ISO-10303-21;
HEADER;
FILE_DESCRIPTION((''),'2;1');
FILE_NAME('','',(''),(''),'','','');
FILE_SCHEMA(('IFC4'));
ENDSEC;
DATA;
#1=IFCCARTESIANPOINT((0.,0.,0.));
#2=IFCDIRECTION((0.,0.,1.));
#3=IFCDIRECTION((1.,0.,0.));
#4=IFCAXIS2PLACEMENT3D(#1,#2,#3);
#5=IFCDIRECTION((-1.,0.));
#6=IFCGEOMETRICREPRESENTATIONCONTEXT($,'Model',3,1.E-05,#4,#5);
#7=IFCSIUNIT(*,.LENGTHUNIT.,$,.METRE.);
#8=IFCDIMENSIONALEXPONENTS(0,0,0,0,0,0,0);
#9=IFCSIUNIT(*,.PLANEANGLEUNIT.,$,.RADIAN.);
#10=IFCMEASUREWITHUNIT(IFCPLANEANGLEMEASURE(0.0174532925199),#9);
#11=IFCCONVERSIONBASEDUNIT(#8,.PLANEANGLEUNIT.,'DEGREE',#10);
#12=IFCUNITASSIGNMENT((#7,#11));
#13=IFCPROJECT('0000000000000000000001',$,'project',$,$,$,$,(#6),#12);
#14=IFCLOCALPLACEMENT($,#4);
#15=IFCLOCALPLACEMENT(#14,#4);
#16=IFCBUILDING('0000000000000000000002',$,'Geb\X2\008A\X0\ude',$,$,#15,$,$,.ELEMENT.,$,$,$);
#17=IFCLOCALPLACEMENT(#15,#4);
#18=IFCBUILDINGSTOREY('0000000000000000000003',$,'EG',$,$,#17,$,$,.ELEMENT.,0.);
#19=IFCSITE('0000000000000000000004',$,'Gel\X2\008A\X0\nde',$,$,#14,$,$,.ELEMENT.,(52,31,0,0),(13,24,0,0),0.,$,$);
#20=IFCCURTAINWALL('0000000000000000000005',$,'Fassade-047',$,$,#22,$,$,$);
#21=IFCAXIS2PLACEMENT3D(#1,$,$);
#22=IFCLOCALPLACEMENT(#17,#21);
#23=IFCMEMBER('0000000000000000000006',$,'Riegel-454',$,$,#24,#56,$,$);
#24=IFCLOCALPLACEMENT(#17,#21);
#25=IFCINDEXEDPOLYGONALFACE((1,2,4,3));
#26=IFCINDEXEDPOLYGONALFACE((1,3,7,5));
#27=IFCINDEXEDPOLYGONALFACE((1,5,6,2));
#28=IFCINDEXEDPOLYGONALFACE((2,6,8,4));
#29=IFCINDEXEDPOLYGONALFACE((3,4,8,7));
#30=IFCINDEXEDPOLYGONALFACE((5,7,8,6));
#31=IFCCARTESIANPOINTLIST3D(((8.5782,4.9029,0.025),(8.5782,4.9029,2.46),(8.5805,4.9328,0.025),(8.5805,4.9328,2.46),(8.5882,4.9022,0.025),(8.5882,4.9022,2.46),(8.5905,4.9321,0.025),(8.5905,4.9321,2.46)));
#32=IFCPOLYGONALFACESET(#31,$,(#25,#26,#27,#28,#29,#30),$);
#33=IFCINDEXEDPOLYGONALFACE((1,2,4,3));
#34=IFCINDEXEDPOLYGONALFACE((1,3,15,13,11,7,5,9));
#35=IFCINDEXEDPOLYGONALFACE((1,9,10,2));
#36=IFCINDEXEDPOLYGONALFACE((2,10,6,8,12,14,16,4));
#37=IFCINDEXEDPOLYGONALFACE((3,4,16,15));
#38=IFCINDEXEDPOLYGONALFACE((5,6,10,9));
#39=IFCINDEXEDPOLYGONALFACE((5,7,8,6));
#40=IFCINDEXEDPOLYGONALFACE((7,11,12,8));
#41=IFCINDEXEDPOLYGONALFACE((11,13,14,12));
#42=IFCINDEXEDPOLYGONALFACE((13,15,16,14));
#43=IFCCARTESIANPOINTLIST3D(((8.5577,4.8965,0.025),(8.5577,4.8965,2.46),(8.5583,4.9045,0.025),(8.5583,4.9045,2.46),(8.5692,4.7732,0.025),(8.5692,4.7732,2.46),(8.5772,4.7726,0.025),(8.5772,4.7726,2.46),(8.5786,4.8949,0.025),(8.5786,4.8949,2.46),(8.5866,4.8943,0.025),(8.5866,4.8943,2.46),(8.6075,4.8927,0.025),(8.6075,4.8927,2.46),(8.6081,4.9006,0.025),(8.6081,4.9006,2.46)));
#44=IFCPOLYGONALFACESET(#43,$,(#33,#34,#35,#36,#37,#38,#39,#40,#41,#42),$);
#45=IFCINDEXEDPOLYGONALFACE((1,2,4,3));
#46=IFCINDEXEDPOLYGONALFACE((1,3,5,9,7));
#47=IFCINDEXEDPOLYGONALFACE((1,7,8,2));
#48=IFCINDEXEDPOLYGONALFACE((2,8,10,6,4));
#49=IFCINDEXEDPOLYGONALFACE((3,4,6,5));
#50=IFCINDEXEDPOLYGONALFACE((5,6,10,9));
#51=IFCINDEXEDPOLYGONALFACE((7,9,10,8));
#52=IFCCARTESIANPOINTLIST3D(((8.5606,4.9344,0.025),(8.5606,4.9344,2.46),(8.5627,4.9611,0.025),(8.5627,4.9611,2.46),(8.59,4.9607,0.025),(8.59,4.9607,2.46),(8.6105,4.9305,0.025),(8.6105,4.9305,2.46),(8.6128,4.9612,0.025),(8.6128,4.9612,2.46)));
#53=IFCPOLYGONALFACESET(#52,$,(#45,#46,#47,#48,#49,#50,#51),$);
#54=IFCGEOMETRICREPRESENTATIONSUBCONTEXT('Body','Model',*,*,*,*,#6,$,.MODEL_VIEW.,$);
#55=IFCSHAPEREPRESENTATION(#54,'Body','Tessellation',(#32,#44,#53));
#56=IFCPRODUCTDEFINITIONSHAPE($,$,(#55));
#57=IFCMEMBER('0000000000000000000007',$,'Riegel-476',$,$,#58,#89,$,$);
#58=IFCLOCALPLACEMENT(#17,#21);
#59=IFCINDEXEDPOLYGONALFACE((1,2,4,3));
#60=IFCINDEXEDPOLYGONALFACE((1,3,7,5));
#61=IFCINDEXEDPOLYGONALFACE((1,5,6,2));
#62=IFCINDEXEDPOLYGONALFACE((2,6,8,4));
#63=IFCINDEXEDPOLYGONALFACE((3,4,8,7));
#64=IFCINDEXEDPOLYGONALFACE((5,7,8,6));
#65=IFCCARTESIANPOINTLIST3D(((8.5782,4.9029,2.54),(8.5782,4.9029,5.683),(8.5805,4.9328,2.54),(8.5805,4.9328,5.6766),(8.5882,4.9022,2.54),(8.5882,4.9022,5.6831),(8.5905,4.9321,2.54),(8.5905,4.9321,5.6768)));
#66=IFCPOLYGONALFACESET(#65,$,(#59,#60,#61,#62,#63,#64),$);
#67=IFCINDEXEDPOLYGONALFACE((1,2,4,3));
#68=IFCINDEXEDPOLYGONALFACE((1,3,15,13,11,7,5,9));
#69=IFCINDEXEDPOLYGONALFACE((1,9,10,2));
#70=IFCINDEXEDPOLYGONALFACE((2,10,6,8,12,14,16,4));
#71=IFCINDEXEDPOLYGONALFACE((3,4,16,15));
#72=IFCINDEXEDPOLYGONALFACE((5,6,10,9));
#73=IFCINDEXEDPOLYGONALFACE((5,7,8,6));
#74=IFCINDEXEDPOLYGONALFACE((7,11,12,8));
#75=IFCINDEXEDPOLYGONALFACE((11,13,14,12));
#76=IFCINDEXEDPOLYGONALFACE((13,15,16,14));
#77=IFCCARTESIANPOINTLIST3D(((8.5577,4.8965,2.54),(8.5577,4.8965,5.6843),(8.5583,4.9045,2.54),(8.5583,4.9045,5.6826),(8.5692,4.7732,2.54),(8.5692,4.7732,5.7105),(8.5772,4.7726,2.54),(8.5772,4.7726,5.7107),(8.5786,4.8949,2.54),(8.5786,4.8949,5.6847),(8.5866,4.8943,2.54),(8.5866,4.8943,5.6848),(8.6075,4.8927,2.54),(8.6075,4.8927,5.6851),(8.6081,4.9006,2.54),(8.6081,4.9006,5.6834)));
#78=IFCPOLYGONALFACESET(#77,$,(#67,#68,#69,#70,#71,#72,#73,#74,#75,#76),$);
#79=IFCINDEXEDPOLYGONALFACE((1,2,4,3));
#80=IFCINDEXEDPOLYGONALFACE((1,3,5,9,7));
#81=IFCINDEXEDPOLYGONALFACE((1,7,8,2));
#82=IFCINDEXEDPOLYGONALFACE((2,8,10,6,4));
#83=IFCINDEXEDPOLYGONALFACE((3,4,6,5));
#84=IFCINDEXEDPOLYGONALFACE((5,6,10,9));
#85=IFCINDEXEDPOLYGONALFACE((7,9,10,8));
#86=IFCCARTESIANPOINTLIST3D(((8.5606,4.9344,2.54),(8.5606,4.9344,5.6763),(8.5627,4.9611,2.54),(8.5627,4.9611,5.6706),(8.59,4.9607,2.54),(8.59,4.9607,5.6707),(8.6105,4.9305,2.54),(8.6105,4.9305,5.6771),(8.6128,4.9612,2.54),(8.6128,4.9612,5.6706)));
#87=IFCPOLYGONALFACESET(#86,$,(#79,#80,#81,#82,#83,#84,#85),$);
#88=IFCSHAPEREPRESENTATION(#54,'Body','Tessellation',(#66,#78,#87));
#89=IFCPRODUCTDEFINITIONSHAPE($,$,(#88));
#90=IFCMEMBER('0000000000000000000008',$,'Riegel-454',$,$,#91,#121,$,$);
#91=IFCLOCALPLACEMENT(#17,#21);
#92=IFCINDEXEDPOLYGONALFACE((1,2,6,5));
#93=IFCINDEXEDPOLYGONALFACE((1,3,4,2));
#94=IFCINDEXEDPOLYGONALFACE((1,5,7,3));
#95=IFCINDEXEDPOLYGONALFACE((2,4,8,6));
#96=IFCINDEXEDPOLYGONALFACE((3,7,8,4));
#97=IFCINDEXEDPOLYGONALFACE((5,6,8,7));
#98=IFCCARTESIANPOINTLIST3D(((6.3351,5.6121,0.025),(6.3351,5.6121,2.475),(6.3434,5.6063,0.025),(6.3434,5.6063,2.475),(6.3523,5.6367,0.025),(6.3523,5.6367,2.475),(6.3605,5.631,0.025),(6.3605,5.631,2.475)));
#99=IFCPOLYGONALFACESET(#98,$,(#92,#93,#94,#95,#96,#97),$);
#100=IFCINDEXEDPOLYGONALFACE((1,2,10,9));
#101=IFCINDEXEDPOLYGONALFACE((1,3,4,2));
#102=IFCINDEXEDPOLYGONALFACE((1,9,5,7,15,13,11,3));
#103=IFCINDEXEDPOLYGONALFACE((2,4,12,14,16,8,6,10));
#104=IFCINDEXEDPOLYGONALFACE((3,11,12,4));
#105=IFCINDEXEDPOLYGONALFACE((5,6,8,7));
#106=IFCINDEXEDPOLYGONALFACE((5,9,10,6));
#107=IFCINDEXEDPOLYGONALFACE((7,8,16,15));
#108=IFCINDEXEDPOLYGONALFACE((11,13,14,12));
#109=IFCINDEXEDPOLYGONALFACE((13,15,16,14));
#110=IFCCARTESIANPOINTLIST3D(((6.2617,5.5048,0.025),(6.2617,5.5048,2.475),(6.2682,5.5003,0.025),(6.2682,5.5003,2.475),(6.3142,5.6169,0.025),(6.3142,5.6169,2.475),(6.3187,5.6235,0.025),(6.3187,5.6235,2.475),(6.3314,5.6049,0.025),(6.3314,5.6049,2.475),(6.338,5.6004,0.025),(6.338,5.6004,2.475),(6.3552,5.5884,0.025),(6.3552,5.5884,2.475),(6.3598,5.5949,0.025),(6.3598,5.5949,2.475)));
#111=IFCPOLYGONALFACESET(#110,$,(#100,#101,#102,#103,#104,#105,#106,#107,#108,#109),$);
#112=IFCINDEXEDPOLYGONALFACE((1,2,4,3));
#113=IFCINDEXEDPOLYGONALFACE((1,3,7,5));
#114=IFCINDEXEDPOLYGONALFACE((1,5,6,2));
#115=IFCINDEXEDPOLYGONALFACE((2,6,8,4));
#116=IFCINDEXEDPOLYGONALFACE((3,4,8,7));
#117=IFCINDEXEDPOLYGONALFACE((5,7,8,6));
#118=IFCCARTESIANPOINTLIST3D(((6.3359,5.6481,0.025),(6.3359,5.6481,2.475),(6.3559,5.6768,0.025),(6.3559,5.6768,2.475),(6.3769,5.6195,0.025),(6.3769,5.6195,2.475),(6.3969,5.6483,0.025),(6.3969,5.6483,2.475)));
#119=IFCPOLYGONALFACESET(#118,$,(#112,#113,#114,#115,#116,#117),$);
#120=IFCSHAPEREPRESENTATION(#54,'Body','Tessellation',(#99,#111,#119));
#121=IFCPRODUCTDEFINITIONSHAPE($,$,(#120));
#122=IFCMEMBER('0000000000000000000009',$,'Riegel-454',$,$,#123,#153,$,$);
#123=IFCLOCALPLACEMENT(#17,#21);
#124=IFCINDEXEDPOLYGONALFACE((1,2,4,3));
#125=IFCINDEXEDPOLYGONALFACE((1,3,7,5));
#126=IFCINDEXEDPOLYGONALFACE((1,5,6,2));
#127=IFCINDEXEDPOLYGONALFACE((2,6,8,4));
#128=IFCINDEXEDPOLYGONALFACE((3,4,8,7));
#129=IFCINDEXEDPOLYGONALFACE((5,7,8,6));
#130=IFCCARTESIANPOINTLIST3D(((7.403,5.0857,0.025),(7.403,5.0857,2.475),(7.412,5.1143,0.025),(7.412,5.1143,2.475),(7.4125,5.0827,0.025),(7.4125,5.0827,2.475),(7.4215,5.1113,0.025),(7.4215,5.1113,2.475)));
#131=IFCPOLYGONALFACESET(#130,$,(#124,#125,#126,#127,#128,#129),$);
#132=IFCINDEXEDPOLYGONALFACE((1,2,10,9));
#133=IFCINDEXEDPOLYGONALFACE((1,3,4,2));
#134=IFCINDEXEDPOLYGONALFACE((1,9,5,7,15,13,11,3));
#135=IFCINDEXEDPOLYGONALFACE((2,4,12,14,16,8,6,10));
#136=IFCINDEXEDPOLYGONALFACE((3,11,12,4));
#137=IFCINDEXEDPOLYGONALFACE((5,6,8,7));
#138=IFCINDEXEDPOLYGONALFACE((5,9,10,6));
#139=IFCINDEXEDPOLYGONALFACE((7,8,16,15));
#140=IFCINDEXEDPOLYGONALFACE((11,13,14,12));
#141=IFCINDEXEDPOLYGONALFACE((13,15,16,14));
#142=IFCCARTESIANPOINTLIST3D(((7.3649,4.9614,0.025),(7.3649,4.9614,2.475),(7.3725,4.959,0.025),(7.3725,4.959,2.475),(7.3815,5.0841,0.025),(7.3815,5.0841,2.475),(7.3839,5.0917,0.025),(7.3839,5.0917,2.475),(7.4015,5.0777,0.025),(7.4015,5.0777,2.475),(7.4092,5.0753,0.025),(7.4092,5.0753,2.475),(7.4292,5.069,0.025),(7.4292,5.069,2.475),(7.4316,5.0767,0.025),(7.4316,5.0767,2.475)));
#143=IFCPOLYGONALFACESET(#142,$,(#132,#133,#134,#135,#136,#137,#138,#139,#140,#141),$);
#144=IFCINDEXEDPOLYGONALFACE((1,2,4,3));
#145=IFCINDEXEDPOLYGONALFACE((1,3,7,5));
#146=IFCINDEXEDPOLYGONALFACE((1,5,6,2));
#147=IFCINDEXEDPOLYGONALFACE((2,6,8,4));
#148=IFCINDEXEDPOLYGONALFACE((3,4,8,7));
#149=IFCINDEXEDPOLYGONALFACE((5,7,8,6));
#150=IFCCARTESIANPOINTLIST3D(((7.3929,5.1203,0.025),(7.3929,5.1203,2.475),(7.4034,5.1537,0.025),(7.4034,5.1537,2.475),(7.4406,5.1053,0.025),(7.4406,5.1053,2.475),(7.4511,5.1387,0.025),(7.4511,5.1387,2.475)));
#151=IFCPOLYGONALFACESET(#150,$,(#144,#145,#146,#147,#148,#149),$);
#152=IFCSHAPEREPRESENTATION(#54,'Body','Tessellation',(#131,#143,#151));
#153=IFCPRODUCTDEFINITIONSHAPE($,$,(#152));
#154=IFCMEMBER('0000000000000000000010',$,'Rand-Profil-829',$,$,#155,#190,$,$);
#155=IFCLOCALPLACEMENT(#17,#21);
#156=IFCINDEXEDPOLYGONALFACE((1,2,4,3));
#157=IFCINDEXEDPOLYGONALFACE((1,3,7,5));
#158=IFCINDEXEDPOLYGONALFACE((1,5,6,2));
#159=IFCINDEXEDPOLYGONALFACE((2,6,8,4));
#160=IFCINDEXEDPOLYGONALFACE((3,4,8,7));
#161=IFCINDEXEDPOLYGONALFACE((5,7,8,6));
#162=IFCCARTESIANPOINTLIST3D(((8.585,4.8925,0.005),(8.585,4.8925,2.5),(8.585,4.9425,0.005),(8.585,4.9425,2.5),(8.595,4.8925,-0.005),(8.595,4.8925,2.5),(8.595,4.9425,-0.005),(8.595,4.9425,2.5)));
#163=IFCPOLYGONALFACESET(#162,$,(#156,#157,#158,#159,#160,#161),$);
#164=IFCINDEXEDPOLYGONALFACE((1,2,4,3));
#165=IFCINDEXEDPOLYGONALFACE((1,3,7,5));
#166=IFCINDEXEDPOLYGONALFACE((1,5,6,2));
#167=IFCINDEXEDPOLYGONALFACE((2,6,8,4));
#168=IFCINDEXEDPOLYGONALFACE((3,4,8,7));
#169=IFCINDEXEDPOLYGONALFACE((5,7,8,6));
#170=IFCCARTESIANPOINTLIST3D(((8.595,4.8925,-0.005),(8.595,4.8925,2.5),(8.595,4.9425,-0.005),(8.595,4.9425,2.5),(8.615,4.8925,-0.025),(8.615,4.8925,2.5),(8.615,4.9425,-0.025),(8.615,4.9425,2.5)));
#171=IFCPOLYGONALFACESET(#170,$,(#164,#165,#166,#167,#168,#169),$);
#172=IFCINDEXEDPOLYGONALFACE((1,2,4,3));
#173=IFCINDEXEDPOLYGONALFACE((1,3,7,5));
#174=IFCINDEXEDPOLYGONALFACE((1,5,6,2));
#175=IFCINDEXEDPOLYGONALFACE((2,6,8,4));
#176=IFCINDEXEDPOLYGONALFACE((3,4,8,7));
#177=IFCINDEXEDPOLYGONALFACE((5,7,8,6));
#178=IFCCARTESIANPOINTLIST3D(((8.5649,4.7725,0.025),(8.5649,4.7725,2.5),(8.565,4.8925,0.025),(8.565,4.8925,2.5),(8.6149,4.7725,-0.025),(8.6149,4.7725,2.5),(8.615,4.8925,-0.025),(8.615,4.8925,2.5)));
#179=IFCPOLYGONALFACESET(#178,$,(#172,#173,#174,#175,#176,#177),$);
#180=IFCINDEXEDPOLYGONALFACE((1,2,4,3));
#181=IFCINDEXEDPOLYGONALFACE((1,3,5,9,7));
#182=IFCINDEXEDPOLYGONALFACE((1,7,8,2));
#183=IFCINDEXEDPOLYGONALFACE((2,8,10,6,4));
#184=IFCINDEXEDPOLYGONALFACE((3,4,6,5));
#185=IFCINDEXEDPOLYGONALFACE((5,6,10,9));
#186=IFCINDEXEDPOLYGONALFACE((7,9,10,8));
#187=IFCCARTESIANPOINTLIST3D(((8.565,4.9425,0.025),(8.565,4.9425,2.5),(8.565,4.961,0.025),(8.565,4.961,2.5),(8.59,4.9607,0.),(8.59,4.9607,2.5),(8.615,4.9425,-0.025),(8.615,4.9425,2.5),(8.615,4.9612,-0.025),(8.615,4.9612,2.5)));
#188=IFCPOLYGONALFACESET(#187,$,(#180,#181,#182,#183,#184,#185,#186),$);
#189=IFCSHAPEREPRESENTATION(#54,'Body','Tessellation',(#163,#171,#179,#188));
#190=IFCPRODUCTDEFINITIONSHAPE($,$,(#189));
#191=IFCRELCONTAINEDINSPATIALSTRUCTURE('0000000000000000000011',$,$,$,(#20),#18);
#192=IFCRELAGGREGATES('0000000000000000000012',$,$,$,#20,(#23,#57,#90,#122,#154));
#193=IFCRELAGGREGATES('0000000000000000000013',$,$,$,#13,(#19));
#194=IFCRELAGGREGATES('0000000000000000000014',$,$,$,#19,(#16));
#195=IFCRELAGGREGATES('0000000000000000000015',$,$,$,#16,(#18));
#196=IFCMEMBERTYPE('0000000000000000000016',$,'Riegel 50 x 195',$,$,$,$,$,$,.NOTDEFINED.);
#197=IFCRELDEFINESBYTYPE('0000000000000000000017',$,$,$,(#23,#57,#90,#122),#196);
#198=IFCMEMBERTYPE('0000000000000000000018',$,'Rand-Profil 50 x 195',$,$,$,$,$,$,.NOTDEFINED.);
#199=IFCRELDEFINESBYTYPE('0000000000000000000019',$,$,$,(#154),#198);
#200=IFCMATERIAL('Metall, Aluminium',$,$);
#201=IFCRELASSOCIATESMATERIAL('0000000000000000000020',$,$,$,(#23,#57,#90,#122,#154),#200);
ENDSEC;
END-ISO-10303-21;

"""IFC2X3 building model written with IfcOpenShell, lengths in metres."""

from ifc_helpers import new_model, entity, si_unit, converted_unit, direction, frame, origin_with_axes, place, context, subcontext, project, spatial, polyline, outline, extrude, clip, halfspace, material, type_object, element, aggregate, save


model = new_model("IFC2X3")

# Units and contexts
model_context = context("Model", 3, precision=1e-05, world=origin_with_axes(), true_north=direction((-1.0, 0.0)))
body_context = subcontext(model_context, "Body", "Model", "MODEL_VIEW")
ifc_project = project(units=[si_unit("LENGTHUNIT", "METRE"), converted_unit("PLANEANGLEUNIT", "DEGREE", entity("IfcPlaneAngleMeasure", 0.0174532925199), si_unit("PLANEANGLEUNIT", "RADIAN"), dimensions=[0, 0, 0, 0, 0, 0, 0])], contexts=[model_context])

# Site, building, storey
site_placement = place(None, origin_with_axes())
site = spatial("IfcSite", under=ifc_project, at=site_placement, Name="Gel\u008ande", CompositionType="ELEMENT", RefLatitude=(52, 31, 0, 0), RefLongitude=(13, 24, 0, 0), RefElevation=0.0)
building_placement = place(site_placement, origin_with_axes())
building = spatial("IfcBuilding", under=site, at=building_placement, Name="Geb\u008aude", CompositionType="ELEMENT")
storey_placement = place(building_placement, origin_with_axes())
storey = spatial("IfcBuildingStorey", under=building, at=storey_placement, Name="EG", CompositionType="ELEMENT", Elevation=0.0)

# Curtain wall, members
curtain_wall_placement = place(storey_placement, frame((7.6056, 12.5904, 0.0), z_axis=(0.0, 0.0, 1.0), x_axis=(1.0, 0.0, 0.0)))
curtain_wall = element("IfcCurtainWall", 1, at=curtain_wall_placement, inside=storey, Name="Fassade-047")
ifc_material_1 = material(Name="Metall, Aluminium")
member_type_1 = type_object("IfcMemberType", Name="Riegel 50 x 195", PredefinedType="NOTDEFINED")
member_1_placement = place(curtain_wall_placement, frame((0.9788, -7.6729, 0.0), z_axis=(0.0, 0.0, 1.0), x_axis=(-0.99704, 0.07688, 0.0)))
member_1 = element("IfcMember", 2, at=member_1_placement, type_object=member_type_1, material=ifc_material_1, Name="Riegel-454", context=body_context, shape_type="SweptSolid", body=[
    extrude(outline(polyline([(-0.0061, -0.0146), (0.0038, -0.0153), (0.0061, 0.0146), (-0.0038, 0.0153), (-0.0061, -0.0146)])), frame((0.0, 0.0, 0.025), z_axis=(0.0, 0.0, 1.0), x_axis=(-0.99704, -0.07688, 0.0)), (0.0, 0.0, 1.0), 2.435),
    extrude(outline(polyline([(-0.0151, -0.1443), (-0.0072, -0.1449), (0.0022, -0.0232), (0.0232, -0.0249), (0.0238, -0.0169), (-0.0261, -0.013), (-0.0267, -0.021), (-0.0058, -0.0226), (-0.0151, -0.1443)])), frame((0.0, 0.0, 0.025), z_axis=(0.0, 0.0, 1.0), x_axis=(-0.99704, -0.07688, 0.0)), (0.0, 0.0, 1.0), 2.435),
    extrude(outline(polyline([(0.0056, 0.0432), (-0.0217, 0.0436), (-0.0238, 0.0169), (0.0261, 0.013), (0.0284, 0.0437), (0.0056, 0.0432)])), frame((0.0, 0.0, 0.025), z_axis=(0.0, 0.0, 1.0), x_axis=(-0.99704, -0.07688, 0.0)), (0.0, 0.0, 1.0), 2.435),
])
member_2_placement = place(curtain_wall_placement, frame((0.9788, -7.6729, 2.5), z_axis=(0.0, 0.0, 1.0), x_axis=(-0.99704, 0.07688, 0.0)))
member_2 = element("IfcMember", 3, at=member_2_placement, type_object=member_type_1, material=ifc_material_1, Name="Riegel-476", context=body_context, shape_type="Clipping", body=[
    clip(extrude(outline(polyline([(0.0061, 0.0146), (-0.0038, 0.0153), (-0.0061, -0.0146), (0.0038, -0.0153), (0.0061, 0.0146)])), frame((0.0, 0.0, 0.04), z_axis=(0.0, 0.0, 1.0), x_axis=(-0.99704, -0.07688, 0.0)), (0.0, 0.0, 1.0), 3.1431), halfspace(frame((0.0497, -0.6448, 3.0424), z_axis=(-0.015984, 0.207296, -0.978148), x_axis=(0.0, -0.978273, -0.207323)), True)),
    clip(extrude(outline(polyline([(0.0238, -0.0169), (-0.0261, -0.013), (-0.0267, -0.021), (-0.0058, -0.0226), (-0.0151, -0.1443), (-0.0072, -0.1449), (0.0022, -0.0232), (0.0232, -0.0249), (0.0238, -0.0169)])), frame((0.0, 0.0, 0.04), z_axis=(0.0, 0.0, 1.0), x_axis=(-0.99704, -0.07688, 0.0)), (0.0, 0.0, 1.0), 3.1707), halfspace(frame((0.0497, -0.6448, 3.0424), z_axis=(-0.015984, 0.207296, -0.978148), x_axis=(0.0, -0.978273, -0.207323)), True)),
    clip(extrude(outline(polyline([(0.0261, 0.013), (0.0284, 0.0437), (0.0056, 0.0432), (-0.0217, 0.0436), (-0.0238, 0.0169), (0.0261, 0.013)])), frame((0.0, 0.0, 0.04), z_axis=(0.0, 0.0, 1.0), x_axis=(-0.99704, -0.07688, 0.0)), (0.0, 0.0, 1.0), 3.1371), halfspace(frame((0.0497, -0.6448, 3.0424), z_axis=(-0.015984, 0.207296, -0.978148), x_axis=(0.0, -0.978273, -0.207323)), True)),
])
member_3_placement = place(curtain_wall_placement, frame((-1.2577, -6.9689, 0.0), z_axis=(0.0, 0.0, 1.0), x_axis=(-0.820519, 0.57162, 0.0)))
member_3 = element("IfcMember", 4, at=member_3_placement, type_object=member_type_1, material=ifc_material_1, Name="Riegel-454", context=body_context, shape_type="SweptSolid", body=[
    extrude(outline(polyline([(-0.0127, -0.0094), (-0.0045, -0.0152), (0.0127, 0.0094), (0.0045, 0.0152), (-0.0127, -0.0094)])), frame((0.0, 0.0, 0.025), z_axis=(0.0, 0.0, 1.0), x_axis=(-0.820519, -0.57162, 0.0)), (0.0, 0.0, 1.0), 2.45),
    extrude(outline(polyline([(-0.0862, -0.1167), (-0.0796, -0.1213), (-0.0099, -0.0212), (0.0074, -0.0332), (0.0119, -0.0266), (-0.0291, 0.002), (-0.0337, -0.0046), (-0.0164, -0.0166), (-0.0862, -0.1167)])), frame((0.0, 0.0, 0.025), z_axis=(0.0, 0.0, 1.0), x_axis=(-0.820519, -0.57162, 0.0)), (0.0, 0.0, 1.0), 2.45),
    extrude(outline(polyline([(0.0491, 0.0267), (0.0081, 0.0553), (-0.0119, 0.0266), (0.0291, -0.002), (0.0491, 0.0267)])), frame((0.0, 0.0, 0.025), z_axis=(0.0, 0.0, 1.0), x_axis=(-0.820519, -0.57162, 0.0)), (0.0, 0.0, 1.0), 2.45),
])
member_4_placement = place(curtain_wall_placement, frame((-0.1933, -7.4919, 0.0), z_axis=(0.0, 0.0, 1.0), x_axis=(-0.95386, 0.300252, 0.0)))
member_4 = element("IfcMember", 5, at=member_4_placement, type_object=member_type_1, material=ifc_material_1, Name="Riegel-454", context=body_context, shape_type="SweptSolid", body=[
    extrude(outline(polyline([(-0.0093, -0.0128), (0.0003, -0.0158), (0.0093, 0.0128), (-0.0003, 0.0158), (-0.0093, -0.0128)])), frame((0.0, 0.0, 0.025), z_axis=(0.0, 0.0, 1.0), x_axis=(-0.95386, -0.300252, 0.0)), (0.0, 0.0, 1.0), 2.45),
    extrude(outline(polyline([(-0.0474, -0.1371), (-0.0397, -0.1395), (-0.0031, -0.0231), (0.0169, -0.0294), (0.0193, -0.0218), (-0.0284, -0.0068), (-0.0308, -0.0144), (-0.0107, -0.0207), (-0.0474, -0.1371)])), frame((0.0, 0.0, 0.025), z_axis=(0.0, 0.0, 1.0), x_axis=(-0.95386, -0.300252, 0.0)), (0.0, 0.0, 1.0), 2.45),
    extrude(outline(polyline([(0.0389, 0.0402), (-0.0088, 0.0552), (-0.0193, 0.0218), (0.0284, 0.0068), (0.0389, 0.0402)])), frame((0.0, 0.0, 0.025), z_axis=(0.0, 0.0, 1.0), x_axis=(-0.95386, -0.300252, 0.0)), (0.0, 0.0, 1.0), 2.45),
])
member_type_2 = type_object("IfcMemberType", Name="Rand-Profil 50 x 195", PredefinedType="NOTDEFINED")
member_5_placement = place(curtain_wall_placement, frame((0.9844, -7.6729, 0.0), z_axis=(0.0, 0.0, 1.0), x_axis=(-1.0, 0.000717, 0.0)))
member_5 = element("IfcMember", 6, at=member_5_placement, type_object=member_type_2, material=ifc_material_1, Name="Rand-Profil-829", context=body_context, shape_type="Clipping", body=[
    clip(extrude(outline(polyline([(-0.005, -0.025), (0.005, -0.025), (0.005, 0.025), (-0.005, 0.025), (-0.005, -0.025)])), frame((0.0, 0.0, -0.005), z_axis=(0.0, 0.0, 1.0), x_axis=(-1.0, -0.000717, 0.0)), (0.0, 0.0, 1.0), 2.505), halfspace(frame((0.0, 0.0, 0.0), z_axis=(-0.707107, 0.0, 0.707107), x_axis=(-0.707107, 0.0, -0.707107)), True)),
    clip(extrude(outline(polyline([(0.005, -0.025), (0.025, -0.025), (0.025, 0.025), (0.005, 0.025), (0.005, -0.025)])), frame((0.0, 0.0, -0.025), z_axis=(0.0, 0.0, 1.0), x_axis=(-1.0, -0.000717, 0.0)), (0.0, 0.0, 1.0), 2.525), halfspace(frame((0.0, 0.0, 0.0), z_axis=(-0.707107, 0.0, 0.707107), x_axis=(-0.707107, 0.0, -0.707107)), True)),
    clip(extrude(outline(polyline([(-0.0251, -0.145), (0.0249, -0.145), (0.025, -0.025), (-0.025, -0.025), (-0.0251, -0.145)])), frame((0.0, 0.0, -0.025), z_axis=(0.0, 0.0, 1.0), x_axis=(-1.0, -0.000717, 0.0)), (0.0, 0.0, 1.0), 2.525), halfspace(frame((0.0, 0.0, 0.0), z_axis=(-0.707107, 0.0, 0.707107), x_axis=(-0.707107, 0.0, -0.707107)), True)),
    clip(extrude(outline(polyline([(0.0, 0.0432), (-0.025, 0.0435), (-0.025, 0.025), (0.025, 0.025), (0.025, 0.0437), (0.0, 0.0432)])), frame((0.0, 0.0, -0.025), z_axis=(0.0, 0.0, 1.0), x_axis=(-1.0, -0.000717, 0.0)), (0.0, 0.0, 1.0), 2.525), halfspace(frame((0.0, 0.0, 0.0), z_axis=(-0.707107, 0.0, 0.707107), x_axis=(-0.707107, 0.0, -0.707107)), True)),
])

aggregate(curtain_wall, [member_1, member_2, member_3, member_4, member_5])

save(model, "model.ifc")
